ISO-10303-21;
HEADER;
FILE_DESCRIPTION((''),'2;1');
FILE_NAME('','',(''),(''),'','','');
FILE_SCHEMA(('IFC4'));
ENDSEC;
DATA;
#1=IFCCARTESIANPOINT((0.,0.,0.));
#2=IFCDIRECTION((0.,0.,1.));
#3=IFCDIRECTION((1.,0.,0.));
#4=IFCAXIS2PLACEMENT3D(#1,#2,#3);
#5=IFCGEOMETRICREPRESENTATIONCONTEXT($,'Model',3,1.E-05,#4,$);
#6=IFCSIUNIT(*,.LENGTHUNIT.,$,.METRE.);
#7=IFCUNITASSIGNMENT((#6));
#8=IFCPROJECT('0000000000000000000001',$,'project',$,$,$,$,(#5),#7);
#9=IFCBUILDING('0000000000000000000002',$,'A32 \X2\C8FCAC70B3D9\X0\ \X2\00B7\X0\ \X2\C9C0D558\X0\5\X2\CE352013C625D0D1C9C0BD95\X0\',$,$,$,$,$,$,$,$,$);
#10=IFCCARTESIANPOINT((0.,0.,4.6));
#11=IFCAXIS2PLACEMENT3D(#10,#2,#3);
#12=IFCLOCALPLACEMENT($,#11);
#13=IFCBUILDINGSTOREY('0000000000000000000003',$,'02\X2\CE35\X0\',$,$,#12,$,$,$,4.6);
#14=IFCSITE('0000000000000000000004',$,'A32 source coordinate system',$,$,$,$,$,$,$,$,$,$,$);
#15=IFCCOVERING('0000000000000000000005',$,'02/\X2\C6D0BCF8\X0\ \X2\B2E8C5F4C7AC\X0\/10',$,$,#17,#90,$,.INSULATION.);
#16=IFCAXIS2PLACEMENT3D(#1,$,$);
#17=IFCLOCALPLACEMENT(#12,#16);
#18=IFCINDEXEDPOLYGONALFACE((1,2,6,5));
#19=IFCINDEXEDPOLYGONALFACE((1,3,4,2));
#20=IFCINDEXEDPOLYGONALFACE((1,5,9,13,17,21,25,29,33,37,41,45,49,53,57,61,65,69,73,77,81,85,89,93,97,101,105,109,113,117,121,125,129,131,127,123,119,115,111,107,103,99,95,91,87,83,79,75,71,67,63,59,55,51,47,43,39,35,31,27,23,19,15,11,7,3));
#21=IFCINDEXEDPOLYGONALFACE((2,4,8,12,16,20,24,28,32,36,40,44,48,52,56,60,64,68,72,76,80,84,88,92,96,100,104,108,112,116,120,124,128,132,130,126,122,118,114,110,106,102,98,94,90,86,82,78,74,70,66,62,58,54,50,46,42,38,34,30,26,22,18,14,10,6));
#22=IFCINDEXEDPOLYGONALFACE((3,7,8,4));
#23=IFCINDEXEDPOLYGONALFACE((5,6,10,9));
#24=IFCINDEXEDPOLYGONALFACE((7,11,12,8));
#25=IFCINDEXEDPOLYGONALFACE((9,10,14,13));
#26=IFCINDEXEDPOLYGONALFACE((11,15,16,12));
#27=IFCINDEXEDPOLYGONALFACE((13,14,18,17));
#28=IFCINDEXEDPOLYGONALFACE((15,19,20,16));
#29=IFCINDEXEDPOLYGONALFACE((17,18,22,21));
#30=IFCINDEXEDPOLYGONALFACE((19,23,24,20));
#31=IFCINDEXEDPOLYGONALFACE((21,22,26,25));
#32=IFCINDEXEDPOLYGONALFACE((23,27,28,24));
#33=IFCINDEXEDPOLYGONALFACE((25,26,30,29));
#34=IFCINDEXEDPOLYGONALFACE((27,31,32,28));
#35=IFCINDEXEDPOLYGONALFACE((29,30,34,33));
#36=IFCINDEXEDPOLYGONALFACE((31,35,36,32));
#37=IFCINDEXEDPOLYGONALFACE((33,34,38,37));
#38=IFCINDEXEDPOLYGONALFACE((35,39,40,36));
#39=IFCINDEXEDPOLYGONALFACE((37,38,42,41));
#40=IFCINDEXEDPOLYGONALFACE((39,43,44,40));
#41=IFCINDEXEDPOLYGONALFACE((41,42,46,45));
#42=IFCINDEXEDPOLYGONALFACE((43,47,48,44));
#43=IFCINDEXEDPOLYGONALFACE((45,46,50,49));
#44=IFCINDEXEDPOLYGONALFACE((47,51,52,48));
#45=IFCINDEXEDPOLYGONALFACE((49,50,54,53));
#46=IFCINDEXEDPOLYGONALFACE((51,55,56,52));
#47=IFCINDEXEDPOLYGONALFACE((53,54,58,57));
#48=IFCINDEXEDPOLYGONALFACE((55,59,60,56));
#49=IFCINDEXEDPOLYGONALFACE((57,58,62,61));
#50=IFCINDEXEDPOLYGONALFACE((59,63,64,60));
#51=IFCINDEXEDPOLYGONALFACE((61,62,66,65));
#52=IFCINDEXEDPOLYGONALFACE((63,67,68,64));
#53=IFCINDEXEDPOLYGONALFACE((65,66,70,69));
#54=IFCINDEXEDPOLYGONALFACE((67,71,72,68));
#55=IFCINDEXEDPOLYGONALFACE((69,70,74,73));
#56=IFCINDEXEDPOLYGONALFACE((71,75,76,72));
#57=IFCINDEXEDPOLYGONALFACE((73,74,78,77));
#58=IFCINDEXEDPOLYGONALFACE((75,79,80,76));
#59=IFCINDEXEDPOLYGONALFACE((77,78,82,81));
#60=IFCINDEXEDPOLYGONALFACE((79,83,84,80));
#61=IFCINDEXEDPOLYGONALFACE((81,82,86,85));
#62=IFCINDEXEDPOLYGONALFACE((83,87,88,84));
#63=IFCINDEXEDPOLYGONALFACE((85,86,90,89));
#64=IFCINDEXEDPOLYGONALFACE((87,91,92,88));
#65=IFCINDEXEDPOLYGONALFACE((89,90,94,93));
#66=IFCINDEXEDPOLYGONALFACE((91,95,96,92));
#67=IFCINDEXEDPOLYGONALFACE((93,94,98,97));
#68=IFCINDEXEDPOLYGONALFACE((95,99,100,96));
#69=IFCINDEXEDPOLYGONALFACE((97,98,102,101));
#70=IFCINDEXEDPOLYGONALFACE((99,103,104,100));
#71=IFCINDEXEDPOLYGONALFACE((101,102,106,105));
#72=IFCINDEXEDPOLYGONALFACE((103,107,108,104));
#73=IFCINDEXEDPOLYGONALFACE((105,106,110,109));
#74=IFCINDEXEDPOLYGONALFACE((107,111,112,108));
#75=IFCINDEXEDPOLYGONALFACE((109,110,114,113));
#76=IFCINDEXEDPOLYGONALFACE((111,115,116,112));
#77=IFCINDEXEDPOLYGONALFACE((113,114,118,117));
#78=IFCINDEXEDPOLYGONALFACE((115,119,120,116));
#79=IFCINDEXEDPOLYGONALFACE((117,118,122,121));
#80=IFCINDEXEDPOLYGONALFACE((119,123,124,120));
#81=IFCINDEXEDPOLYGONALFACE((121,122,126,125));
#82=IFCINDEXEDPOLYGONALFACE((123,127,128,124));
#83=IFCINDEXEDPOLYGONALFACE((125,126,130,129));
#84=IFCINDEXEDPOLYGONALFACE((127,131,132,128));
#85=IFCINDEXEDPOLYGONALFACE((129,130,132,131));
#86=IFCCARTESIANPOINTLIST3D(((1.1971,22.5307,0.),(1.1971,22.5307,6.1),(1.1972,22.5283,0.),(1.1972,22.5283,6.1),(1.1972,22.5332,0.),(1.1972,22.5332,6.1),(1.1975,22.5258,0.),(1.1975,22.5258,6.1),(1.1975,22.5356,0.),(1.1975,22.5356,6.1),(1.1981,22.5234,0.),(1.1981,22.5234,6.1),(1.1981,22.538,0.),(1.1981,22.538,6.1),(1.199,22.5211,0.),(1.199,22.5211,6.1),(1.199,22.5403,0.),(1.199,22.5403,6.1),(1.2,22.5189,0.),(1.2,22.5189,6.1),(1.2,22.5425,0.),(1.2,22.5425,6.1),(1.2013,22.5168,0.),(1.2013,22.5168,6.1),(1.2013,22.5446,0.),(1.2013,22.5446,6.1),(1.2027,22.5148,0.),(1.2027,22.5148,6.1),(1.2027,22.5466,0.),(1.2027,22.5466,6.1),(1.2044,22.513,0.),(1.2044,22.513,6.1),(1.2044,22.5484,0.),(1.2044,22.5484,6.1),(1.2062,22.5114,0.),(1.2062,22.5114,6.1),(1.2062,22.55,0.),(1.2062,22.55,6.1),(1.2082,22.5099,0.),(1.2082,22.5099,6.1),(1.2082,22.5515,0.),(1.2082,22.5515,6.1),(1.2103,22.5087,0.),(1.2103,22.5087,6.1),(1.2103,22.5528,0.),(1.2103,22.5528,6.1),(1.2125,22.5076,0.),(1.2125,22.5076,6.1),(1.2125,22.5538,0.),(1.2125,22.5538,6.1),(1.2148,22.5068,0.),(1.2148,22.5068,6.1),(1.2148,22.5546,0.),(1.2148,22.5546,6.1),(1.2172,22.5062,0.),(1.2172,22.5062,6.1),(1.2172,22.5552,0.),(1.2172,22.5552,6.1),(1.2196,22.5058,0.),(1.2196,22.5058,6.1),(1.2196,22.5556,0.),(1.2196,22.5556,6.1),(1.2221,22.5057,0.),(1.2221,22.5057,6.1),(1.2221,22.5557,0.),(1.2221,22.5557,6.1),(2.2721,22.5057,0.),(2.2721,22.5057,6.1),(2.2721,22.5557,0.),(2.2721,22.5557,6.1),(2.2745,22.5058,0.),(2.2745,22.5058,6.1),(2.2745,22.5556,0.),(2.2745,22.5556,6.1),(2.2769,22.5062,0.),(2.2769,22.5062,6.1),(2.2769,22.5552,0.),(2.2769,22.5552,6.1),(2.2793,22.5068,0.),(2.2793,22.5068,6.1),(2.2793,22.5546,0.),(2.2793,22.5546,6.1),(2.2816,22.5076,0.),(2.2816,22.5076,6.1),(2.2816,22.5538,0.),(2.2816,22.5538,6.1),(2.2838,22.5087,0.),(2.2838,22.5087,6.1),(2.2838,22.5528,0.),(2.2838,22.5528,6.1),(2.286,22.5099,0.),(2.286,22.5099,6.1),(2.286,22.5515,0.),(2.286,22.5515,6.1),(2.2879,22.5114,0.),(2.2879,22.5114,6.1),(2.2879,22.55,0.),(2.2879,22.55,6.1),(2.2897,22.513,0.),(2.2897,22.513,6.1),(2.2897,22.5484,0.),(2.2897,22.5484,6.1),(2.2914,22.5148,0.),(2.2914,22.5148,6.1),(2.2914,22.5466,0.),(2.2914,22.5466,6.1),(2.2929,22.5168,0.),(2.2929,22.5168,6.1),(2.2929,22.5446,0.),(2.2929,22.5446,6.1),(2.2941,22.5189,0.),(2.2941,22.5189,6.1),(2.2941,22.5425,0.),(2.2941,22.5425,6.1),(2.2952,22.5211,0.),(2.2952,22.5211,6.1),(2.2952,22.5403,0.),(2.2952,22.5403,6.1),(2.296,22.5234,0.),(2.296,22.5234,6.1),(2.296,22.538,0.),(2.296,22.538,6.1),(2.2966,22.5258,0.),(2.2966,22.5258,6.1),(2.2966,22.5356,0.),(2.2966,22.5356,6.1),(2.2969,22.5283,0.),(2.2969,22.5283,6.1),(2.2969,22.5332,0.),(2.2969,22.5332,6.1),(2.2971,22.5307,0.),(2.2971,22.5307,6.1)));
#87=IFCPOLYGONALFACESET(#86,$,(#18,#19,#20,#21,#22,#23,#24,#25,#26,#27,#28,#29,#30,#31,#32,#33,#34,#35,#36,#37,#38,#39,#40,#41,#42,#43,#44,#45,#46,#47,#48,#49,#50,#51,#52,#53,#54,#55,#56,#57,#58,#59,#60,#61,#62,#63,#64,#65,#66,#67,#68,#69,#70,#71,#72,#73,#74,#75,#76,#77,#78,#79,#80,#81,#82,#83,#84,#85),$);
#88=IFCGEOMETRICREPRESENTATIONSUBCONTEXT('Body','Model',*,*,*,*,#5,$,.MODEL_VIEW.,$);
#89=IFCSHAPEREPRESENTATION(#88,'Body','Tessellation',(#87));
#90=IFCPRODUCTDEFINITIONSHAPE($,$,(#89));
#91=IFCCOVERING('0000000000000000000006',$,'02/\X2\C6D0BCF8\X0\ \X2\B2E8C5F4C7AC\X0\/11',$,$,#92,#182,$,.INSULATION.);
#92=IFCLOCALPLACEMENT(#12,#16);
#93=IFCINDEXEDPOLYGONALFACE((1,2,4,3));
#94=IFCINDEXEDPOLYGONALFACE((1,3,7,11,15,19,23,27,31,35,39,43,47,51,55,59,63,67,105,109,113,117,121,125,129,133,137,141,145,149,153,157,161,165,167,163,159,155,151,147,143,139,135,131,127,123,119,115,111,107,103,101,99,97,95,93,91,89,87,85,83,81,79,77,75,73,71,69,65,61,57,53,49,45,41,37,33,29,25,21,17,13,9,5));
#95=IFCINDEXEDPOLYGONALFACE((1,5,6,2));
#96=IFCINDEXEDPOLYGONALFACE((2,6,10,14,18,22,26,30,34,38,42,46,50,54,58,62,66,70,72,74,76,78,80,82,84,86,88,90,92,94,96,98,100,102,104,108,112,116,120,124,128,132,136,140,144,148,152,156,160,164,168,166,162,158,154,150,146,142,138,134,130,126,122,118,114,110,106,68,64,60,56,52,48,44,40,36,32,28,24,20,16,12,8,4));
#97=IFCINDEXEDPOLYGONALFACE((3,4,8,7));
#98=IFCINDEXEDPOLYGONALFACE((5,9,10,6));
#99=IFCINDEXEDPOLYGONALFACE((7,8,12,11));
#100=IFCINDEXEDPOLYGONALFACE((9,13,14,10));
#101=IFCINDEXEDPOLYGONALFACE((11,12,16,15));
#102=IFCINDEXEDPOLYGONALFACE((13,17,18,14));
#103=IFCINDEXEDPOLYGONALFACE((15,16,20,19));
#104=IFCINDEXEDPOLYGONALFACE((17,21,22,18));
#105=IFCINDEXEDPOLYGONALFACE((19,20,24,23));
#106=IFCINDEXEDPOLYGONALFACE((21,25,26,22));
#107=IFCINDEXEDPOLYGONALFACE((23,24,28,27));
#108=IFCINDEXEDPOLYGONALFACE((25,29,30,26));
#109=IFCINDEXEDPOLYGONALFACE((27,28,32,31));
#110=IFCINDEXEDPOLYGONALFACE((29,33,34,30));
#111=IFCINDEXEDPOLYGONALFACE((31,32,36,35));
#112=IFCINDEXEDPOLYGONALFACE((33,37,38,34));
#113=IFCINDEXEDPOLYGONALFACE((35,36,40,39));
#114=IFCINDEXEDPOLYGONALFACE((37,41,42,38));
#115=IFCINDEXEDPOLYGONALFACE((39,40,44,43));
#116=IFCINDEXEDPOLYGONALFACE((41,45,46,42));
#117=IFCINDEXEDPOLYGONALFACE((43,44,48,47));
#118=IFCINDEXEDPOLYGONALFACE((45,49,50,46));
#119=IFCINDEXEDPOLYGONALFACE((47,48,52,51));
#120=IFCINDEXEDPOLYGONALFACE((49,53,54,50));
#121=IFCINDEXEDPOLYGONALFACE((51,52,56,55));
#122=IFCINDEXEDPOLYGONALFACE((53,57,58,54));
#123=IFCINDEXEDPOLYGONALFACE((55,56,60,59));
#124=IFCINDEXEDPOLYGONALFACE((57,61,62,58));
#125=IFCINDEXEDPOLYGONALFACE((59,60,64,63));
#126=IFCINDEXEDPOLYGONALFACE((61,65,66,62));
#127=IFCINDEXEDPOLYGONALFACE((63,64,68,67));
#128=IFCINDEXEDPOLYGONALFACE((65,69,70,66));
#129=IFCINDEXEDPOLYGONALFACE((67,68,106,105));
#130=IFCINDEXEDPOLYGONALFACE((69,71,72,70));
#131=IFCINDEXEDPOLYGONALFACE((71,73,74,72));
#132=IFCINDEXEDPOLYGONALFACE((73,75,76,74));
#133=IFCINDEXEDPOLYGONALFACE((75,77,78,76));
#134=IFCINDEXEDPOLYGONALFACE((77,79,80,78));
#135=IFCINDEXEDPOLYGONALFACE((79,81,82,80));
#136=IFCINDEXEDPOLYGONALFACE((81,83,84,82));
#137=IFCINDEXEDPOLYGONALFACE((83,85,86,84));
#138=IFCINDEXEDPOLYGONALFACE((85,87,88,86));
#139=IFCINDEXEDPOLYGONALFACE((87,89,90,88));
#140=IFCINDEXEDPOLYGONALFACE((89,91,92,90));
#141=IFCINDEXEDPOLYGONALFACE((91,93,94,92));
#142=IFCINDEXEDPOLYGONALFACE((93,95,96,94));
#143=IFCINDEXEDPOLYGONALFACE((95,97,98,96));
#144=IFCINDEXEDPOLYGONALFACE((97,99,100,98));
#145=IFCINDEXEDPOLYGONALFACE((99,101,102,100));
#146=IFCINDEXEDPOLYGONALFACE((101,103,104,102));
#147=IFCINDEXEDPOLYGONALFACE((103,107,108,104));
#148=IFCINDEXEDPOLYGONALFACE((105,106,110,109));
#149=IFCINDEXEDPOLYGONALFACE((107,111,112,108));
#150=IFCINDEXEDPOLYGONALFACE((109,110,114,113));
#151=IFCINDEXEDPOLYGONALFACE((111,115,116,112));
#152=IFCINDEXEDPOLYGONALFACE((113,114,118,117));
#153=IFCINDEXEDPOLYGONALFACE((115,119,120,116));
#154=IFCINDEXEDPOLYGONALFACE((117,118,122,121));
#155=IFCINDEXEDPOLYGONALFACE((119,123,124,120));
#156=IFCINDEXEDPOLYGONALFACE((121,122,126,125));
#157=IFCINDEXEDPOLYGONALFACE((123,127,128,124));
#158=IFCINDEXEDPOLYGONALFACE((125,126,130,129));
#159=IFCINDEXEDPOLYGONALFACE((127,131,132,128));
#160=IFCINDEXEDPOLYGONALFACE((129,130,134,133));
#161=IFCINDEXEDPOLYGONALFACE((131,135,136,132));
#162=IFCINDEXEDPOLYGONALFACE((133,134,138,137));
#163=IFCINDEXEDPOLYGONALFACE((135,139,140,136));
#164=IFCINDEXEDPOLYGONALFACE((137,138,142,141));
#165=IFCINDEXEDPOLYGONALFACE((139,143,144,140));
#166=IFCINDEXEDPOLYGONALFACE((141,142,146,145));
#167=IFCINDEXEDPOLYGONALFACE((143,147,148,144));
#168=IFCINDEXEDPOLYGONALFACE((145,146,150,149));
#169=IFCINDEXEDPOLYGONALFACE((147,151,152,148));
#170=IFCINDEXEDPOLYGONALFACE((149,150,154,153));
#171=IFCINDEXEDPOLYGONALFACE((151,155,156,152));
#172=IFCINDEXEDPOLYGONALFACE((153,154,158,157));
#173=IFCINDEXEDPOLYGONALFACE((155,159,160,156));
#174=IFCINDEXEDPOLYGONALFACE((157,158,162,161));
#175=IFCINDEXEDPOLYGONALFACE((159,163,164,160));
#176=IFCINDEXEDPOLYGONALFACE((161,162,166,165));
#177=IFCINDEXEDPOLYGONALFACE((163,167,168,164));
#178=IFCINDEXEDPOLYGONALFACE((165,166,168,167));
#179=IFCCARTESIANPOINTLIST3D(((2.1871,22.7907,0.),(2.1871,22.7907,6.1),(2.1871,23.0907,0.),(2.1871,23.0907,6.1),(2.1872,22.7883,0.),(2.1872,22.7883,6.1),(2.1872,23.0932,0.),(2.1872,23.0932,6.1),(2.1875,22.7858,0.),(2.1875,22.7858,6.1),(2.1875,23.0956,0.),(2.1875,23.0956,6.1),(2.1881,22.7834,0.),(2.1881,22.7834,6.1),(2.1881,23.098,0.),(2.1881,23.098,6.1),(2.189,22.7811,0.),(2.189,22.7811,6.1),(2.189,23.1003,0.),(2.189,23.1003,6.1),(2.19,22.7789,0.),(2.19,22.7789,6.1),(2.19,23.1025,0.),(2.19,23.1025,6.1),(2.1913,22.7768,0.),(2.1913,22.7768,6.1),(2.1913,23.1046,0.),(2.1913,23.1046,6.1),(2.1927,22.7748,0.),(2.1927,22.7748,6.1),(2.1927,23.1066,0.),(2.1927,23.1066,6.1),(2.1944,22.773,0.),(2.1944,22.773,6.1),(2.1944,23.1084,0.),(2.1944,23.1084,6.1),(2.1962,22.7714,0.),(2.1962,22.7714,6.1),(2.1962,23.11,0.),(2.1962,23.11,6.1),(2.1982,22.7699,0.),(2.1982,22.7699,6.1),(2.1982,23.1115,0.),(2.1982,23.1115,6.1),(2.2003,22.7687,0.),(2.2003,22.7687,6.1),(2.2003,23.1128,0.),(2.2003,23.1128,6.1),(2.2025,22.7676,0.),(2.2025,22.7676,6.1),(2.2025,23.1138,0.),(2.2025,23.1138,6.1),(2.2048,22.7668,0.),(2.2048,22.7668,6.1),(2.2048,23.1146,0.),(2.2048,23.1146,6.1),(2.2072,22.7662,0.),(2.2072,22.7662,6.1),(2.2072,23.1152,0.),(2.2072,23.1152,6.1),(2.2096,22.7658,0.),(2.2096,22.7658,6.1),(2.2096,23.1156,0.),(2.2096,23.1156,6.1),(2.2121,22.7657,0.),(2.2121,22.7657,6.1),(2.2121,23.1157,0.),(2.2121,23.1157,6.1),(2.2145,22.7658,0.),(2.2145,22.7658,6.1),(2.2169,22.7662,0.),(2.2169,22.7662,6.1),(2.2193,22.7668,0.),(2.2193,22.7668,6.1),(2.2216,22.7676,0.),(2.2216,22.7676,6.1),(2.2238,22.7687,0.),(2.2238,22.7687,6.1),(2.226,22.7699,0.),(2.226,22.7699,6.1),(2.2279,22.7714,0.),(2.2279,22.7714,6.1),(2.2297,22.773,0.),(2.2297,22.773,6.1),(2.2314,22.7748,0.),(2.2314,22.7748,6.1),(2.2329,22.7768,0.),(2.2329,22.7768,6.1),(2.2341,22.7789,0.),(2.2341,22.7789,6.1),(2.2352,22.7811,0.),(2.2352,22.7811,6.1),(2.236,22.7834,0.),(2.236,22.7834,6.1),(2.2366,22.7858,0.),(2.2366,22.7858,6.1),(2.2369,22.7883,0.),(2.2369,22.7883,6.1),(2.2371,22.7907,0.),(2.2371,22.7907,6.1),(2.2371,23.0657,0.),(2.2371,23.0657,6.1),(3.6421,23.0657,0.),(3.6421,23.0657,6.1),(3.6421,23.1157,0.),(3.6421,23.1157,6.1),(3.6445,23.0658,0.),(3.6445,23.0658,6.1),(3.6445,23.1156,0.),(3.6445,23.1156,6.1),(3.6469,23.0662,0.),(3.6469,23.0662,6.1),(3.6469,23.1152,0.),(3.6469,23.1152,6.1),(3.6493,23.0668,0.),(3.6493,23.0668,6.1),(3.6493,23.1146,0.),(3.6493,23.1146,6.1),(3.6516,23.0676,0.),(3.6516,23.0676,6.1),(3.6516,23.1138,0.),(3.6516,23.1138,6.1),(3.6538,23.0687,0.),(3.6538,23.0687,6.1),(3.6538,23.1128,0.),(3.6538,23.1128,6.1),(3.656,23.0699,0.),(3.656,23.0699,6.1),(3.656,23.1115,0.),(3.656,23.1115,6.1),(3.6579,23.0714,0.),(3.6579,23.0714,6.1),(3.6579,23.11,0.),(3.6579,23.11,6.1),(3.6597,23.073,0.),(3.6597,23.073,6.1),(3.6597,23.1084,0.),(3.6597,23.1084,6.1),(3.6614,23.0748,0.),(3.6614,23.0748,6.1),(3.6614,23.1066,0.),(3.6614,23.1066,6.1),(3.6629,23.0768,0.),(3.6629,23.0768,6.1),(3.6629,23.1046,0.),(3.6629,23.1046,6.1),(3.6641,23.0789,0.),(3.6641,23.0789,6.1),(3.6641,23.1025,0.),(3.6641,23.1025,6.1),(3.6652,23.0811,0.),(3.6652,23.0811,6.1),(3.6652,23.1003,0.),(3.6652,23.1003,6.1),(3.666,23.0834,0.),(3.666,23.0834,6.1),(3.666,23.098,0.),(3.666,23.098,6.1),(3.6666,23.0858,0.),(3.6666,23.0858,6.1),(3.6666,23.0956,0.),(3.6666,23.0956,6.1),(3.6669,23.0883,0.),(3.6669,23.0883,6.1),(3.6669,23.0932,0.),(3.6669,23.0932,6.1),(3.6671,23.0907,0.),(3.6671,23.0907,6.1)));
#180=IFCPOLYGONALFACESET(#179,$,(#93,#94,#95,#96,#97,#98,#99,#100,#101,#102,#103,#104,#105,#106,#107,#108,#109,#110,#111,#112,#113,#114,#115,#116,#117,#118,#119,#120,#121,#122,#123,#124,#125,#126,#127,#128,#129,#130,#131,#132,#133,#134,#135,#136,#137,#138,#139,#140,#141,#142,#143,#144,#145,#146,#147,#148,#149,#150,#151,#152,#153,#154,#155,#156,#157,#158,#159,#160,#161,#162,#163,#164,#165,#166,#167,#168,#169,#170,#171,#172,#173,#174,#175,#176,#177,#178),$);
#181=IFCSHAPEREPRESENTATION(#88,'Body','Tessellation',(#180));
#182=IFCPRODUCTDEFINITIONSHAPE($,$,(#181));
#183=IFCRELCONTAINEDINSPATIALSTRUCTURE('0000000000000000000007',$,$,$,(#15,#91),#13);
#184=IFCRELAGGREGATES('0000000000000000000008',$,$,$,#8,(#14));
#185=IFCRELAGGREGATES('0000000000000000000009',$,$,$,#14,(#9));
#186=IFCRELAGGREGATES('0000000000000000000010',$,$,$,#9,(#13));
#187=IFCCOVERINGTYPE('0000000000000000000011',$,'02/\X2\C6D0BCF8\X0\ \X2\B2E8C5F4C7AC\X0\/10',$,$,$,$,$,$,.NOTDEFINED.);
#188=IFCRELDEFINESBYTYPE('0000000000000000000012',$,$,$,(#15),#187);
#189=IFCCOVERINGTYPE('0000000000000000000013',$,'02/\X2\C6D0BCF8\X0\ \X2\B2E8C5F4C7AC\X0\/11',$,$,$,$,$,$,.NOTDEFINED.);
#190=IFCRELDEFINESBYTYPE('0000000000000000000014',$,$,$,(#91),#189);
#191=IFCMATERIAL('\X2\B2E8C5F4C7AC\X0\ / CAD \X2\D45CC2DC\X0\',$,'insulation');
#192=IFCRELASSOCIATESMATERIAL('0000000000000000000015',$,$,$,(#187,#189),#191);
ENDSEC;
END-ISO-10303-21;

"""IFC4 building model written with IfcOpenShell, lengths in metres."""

from ifc_helpers import new_model, si_unit, frame, origin, origin_with_axes, place, context, subcontext, project, spatial, polyline, outline, extrude, source, transform, mapped, material, type_object, type_shapes, element, save


model = new_model("IFC4")

# Units and contexts
model_context = context("Model", 3, precision=1e-05, world=origin_with_axes())
body_context = subcontext(model_context, "Body", "Model", "MODEL_VIEW")
ifc_project = project(units=[si_unit("LENGTHUNIT", "METRE")], contexts=[model_context])

# Site, building, storey
site = spatial("IfcSite", under=ifc_project, Name="A32 source coordinate system")
building = spatial("IfcBuilding", under=site, Name="A32 주거동 · 지하5층–옥탑지붕")
storey_placement = place(None, frame((0.0, 0.0, 4.6), z_axis=(0.0, 0.0, 1.0), x_axis=(1.0, 0.0, 0.0)))
storey = spatial("IfcBuildingStorey", under=building, at=storey_placement, Name="02층", Elevation=4.6)

# Coverings
ifc_material = material(Name="단열재 / CAD 표시", Category="insulation")
covering_type_1 = type_object("IfcCoveringType", Name="02/원본 단열재/10", PredefinedType="NOTDEFINED", material=ifc_material)
shared_shape_1 = source(origin(), body_context, "Body", "SweptSolid", [
    extrude(outline(polyline([(2.2838, 22.5528), (2.286, 22.5515), (2.2879, 22.55), (2.2897, 22.5484), (2.2914, 22.5466), (2.2929, 22.5446), (2.2941, 22.5425), (2.2952, 22.5403), (2.296, 22.538), (2.2966, 22.5356), (2.2969, 22.5332), (2.2971, 22.5307), (2.2969, 22.5283), (2.2966, 22.5258), (2.296, 22.5234), (2.2952, 22.5211), (2.2941, 22.5189), (2.2929, 22.5168), (2.2914, 22.5148), (2.2897, 22.513), (2.2879, 22.5114), (2.286, 22.5099), (2.2838, 22.5087), (2.2816, 22.5076), (2.2793, 22.5068), (2.2769, 22.5062), (2.2745, 22.5058), (2.2721, 22.5057), (1.2221, 22.5057), (1.2196, 22.5058), (1.2172, 22.5062), (1.2148, 22.5068), (1.2125, 22.5076), (1.2103, 22.5087), (1.2082, 22.5099), (1.2062, 22.5114), (1.2044, 22.513), (1.2027, 22.5148), (1.2013, 22.5168), (1.2, 22.5189), (1.199, 22.5211), (1.1981, 22.5234), (1.1975, 22.5258), (1.1972, 22.5283), (1.1971, 22.5307), (1.1972, 22.5332), (1.1975, 22.5356), (1.1981, 22.538), (1.199, 22.5403), (1.2, 22.5425), (1.2013, 22.5446), (1.2027, 22.5466), (1.2044, 22.5484), (1.2062, 22.55), (1.2082, 22.5515), (1.2103, 22.5528), (1.2125, 22.5538), (1.2148, 22.5546), (1.2172, 22.5552), (1.2196, 22.5556), (1.2221, 22.5557), (2.2721, 22.5557), (2.2745, 22.5556), (2.2769, 22.5552), (2.2793, 22.5546), (2.2816, 22.5538), (2.2838, 22.5528)])), origin(), (0.0, 0.0, 1.0), 6.1),
])
type_shapes(covering_type_1, [shared_shape_1])
covering_1_placement = place(storey_placement, origin_with_axes())
element("IfcCovering", 1, at=covering_1_placement, inside=storey, type_object=covering_type_1, Name="02/원본 단열재/10", PredefinedType="INSULATION", context=body_context, shape_type="MappedRepresentation", body=[
    mapped(shared_shape_1, transform((0.0, 0.0, 0.0), scale=1.0)),
])
covering_type_2 = type_object("IfcCoveringType", Name="02/원본 단열재/11", PredefinedType="NOTDEFINED", material=ifc_material)
shared_shape_2 = source(origin(), body_context, "Body", "SweptSolid", [
    extrude(outline(polyline([(2.19, 23.1025), (2.1913, 23.1046), (2.1927, 23.1066), (2.1944, 23.1084), (2.1962, 23.11), (2.1982, 23.1115), (2.2003, 23.1128), (2.2025, 23.1138), (2.2048, 23.1146), (2.2072, 23.1152), (2.2096, 23.1156), (2.2121, 23.1157), (3.6421, 23.1157), (3.6445, 23.1156), (3.6469, 23.1152), (3.6493, 23.1146), (3.6516, 23.1138), (3.6538, 23.1128), (3.656, 23.1115), (3.6579, 23.11), (3.6597, 23.1084), (3.6614, 23.1066), (3.6629, 23.1046), (3.6641, 23.1025), (3.6652, 23.1003), (3.666, 23.098), (3.6666, 23.0956), (3.6669, 23.0932), (3.6671, 23.0907), (3.6669, 23.0883), (3.6666, 23.0858), (3.666, 23.0834), (3.6652, 23.0811), (3.6641, 23.0789), (3.6629, 23.0768), (3.6614, 23.0748), (3.6597, 23.073), (3.6579, 23.0714), (3.656, 23.0699), (3.6538, 23.0687), (3.6516, 23.0676), (3.6493, 23.0668), (3.6469, 23.0662), (3.6445, 23.0658), (3.6421, 23.0657), (2.2371, 23.0657), (2.2371, 22.7907), (2.2369, 22.7883), (2.2366, 22.7858), (2.236, 22.7834), (2.2352, 22.7811), (2.2341, 22.7789), (2.2329, 22.7768), (2.2314, 22.7748), (2.2297, 22.773), (2.2279, 22.7714), (2.226, 22.7699), (2.2238, 22.7687), (2.2216, 22.7676), (2.2193, 22.7668), (2.2169, 22.7662), (2.2145, 22.7658), (2.2121, 22.7657), (2.2096, 22.7658), (2.2072, 22.7662), (2.2048, 22.7668), (2.2025, 22.7676), (2.2003, 22.7687), (2.1982, 22.7699), (2.1962, 22.7714), (2.1944, 22.773), (2.1927, 22.7748), (2.1913, 22.7768), (2.19, 22.7789), (2.189, 22.7811), (2.1881, 22.7834), (2.1875, 22.7858), (2.1872, 22.7883), (2.1871, 22.7907), (2.1871, 23.0907), (2.1872, 23.0932), (2.1875, 23.0956), (2.1881, 23.098), (2.189, 23.1003), (2.19, 23.1025)])), origin(), (0.0, 0.0, 1.0), 6.1),
])
type_shapes(covering_type_2, [shared_shape_2])
covering_2_placement = place(storey_placement, origin_with_axes())
element("IfcCovering", 2, at=covering_2_placement, inside=storey, type_object=covering_type_2, Name="02/원본 단열재/11", PredefinedType="INSULATION", context=body_context, shape_type="MappedRepresentation", body=[
    mapped(shared_shape_2, transform((0.0, 0.0, 0.0), scale=1.0)),
])

save(model, "model.ifc")
